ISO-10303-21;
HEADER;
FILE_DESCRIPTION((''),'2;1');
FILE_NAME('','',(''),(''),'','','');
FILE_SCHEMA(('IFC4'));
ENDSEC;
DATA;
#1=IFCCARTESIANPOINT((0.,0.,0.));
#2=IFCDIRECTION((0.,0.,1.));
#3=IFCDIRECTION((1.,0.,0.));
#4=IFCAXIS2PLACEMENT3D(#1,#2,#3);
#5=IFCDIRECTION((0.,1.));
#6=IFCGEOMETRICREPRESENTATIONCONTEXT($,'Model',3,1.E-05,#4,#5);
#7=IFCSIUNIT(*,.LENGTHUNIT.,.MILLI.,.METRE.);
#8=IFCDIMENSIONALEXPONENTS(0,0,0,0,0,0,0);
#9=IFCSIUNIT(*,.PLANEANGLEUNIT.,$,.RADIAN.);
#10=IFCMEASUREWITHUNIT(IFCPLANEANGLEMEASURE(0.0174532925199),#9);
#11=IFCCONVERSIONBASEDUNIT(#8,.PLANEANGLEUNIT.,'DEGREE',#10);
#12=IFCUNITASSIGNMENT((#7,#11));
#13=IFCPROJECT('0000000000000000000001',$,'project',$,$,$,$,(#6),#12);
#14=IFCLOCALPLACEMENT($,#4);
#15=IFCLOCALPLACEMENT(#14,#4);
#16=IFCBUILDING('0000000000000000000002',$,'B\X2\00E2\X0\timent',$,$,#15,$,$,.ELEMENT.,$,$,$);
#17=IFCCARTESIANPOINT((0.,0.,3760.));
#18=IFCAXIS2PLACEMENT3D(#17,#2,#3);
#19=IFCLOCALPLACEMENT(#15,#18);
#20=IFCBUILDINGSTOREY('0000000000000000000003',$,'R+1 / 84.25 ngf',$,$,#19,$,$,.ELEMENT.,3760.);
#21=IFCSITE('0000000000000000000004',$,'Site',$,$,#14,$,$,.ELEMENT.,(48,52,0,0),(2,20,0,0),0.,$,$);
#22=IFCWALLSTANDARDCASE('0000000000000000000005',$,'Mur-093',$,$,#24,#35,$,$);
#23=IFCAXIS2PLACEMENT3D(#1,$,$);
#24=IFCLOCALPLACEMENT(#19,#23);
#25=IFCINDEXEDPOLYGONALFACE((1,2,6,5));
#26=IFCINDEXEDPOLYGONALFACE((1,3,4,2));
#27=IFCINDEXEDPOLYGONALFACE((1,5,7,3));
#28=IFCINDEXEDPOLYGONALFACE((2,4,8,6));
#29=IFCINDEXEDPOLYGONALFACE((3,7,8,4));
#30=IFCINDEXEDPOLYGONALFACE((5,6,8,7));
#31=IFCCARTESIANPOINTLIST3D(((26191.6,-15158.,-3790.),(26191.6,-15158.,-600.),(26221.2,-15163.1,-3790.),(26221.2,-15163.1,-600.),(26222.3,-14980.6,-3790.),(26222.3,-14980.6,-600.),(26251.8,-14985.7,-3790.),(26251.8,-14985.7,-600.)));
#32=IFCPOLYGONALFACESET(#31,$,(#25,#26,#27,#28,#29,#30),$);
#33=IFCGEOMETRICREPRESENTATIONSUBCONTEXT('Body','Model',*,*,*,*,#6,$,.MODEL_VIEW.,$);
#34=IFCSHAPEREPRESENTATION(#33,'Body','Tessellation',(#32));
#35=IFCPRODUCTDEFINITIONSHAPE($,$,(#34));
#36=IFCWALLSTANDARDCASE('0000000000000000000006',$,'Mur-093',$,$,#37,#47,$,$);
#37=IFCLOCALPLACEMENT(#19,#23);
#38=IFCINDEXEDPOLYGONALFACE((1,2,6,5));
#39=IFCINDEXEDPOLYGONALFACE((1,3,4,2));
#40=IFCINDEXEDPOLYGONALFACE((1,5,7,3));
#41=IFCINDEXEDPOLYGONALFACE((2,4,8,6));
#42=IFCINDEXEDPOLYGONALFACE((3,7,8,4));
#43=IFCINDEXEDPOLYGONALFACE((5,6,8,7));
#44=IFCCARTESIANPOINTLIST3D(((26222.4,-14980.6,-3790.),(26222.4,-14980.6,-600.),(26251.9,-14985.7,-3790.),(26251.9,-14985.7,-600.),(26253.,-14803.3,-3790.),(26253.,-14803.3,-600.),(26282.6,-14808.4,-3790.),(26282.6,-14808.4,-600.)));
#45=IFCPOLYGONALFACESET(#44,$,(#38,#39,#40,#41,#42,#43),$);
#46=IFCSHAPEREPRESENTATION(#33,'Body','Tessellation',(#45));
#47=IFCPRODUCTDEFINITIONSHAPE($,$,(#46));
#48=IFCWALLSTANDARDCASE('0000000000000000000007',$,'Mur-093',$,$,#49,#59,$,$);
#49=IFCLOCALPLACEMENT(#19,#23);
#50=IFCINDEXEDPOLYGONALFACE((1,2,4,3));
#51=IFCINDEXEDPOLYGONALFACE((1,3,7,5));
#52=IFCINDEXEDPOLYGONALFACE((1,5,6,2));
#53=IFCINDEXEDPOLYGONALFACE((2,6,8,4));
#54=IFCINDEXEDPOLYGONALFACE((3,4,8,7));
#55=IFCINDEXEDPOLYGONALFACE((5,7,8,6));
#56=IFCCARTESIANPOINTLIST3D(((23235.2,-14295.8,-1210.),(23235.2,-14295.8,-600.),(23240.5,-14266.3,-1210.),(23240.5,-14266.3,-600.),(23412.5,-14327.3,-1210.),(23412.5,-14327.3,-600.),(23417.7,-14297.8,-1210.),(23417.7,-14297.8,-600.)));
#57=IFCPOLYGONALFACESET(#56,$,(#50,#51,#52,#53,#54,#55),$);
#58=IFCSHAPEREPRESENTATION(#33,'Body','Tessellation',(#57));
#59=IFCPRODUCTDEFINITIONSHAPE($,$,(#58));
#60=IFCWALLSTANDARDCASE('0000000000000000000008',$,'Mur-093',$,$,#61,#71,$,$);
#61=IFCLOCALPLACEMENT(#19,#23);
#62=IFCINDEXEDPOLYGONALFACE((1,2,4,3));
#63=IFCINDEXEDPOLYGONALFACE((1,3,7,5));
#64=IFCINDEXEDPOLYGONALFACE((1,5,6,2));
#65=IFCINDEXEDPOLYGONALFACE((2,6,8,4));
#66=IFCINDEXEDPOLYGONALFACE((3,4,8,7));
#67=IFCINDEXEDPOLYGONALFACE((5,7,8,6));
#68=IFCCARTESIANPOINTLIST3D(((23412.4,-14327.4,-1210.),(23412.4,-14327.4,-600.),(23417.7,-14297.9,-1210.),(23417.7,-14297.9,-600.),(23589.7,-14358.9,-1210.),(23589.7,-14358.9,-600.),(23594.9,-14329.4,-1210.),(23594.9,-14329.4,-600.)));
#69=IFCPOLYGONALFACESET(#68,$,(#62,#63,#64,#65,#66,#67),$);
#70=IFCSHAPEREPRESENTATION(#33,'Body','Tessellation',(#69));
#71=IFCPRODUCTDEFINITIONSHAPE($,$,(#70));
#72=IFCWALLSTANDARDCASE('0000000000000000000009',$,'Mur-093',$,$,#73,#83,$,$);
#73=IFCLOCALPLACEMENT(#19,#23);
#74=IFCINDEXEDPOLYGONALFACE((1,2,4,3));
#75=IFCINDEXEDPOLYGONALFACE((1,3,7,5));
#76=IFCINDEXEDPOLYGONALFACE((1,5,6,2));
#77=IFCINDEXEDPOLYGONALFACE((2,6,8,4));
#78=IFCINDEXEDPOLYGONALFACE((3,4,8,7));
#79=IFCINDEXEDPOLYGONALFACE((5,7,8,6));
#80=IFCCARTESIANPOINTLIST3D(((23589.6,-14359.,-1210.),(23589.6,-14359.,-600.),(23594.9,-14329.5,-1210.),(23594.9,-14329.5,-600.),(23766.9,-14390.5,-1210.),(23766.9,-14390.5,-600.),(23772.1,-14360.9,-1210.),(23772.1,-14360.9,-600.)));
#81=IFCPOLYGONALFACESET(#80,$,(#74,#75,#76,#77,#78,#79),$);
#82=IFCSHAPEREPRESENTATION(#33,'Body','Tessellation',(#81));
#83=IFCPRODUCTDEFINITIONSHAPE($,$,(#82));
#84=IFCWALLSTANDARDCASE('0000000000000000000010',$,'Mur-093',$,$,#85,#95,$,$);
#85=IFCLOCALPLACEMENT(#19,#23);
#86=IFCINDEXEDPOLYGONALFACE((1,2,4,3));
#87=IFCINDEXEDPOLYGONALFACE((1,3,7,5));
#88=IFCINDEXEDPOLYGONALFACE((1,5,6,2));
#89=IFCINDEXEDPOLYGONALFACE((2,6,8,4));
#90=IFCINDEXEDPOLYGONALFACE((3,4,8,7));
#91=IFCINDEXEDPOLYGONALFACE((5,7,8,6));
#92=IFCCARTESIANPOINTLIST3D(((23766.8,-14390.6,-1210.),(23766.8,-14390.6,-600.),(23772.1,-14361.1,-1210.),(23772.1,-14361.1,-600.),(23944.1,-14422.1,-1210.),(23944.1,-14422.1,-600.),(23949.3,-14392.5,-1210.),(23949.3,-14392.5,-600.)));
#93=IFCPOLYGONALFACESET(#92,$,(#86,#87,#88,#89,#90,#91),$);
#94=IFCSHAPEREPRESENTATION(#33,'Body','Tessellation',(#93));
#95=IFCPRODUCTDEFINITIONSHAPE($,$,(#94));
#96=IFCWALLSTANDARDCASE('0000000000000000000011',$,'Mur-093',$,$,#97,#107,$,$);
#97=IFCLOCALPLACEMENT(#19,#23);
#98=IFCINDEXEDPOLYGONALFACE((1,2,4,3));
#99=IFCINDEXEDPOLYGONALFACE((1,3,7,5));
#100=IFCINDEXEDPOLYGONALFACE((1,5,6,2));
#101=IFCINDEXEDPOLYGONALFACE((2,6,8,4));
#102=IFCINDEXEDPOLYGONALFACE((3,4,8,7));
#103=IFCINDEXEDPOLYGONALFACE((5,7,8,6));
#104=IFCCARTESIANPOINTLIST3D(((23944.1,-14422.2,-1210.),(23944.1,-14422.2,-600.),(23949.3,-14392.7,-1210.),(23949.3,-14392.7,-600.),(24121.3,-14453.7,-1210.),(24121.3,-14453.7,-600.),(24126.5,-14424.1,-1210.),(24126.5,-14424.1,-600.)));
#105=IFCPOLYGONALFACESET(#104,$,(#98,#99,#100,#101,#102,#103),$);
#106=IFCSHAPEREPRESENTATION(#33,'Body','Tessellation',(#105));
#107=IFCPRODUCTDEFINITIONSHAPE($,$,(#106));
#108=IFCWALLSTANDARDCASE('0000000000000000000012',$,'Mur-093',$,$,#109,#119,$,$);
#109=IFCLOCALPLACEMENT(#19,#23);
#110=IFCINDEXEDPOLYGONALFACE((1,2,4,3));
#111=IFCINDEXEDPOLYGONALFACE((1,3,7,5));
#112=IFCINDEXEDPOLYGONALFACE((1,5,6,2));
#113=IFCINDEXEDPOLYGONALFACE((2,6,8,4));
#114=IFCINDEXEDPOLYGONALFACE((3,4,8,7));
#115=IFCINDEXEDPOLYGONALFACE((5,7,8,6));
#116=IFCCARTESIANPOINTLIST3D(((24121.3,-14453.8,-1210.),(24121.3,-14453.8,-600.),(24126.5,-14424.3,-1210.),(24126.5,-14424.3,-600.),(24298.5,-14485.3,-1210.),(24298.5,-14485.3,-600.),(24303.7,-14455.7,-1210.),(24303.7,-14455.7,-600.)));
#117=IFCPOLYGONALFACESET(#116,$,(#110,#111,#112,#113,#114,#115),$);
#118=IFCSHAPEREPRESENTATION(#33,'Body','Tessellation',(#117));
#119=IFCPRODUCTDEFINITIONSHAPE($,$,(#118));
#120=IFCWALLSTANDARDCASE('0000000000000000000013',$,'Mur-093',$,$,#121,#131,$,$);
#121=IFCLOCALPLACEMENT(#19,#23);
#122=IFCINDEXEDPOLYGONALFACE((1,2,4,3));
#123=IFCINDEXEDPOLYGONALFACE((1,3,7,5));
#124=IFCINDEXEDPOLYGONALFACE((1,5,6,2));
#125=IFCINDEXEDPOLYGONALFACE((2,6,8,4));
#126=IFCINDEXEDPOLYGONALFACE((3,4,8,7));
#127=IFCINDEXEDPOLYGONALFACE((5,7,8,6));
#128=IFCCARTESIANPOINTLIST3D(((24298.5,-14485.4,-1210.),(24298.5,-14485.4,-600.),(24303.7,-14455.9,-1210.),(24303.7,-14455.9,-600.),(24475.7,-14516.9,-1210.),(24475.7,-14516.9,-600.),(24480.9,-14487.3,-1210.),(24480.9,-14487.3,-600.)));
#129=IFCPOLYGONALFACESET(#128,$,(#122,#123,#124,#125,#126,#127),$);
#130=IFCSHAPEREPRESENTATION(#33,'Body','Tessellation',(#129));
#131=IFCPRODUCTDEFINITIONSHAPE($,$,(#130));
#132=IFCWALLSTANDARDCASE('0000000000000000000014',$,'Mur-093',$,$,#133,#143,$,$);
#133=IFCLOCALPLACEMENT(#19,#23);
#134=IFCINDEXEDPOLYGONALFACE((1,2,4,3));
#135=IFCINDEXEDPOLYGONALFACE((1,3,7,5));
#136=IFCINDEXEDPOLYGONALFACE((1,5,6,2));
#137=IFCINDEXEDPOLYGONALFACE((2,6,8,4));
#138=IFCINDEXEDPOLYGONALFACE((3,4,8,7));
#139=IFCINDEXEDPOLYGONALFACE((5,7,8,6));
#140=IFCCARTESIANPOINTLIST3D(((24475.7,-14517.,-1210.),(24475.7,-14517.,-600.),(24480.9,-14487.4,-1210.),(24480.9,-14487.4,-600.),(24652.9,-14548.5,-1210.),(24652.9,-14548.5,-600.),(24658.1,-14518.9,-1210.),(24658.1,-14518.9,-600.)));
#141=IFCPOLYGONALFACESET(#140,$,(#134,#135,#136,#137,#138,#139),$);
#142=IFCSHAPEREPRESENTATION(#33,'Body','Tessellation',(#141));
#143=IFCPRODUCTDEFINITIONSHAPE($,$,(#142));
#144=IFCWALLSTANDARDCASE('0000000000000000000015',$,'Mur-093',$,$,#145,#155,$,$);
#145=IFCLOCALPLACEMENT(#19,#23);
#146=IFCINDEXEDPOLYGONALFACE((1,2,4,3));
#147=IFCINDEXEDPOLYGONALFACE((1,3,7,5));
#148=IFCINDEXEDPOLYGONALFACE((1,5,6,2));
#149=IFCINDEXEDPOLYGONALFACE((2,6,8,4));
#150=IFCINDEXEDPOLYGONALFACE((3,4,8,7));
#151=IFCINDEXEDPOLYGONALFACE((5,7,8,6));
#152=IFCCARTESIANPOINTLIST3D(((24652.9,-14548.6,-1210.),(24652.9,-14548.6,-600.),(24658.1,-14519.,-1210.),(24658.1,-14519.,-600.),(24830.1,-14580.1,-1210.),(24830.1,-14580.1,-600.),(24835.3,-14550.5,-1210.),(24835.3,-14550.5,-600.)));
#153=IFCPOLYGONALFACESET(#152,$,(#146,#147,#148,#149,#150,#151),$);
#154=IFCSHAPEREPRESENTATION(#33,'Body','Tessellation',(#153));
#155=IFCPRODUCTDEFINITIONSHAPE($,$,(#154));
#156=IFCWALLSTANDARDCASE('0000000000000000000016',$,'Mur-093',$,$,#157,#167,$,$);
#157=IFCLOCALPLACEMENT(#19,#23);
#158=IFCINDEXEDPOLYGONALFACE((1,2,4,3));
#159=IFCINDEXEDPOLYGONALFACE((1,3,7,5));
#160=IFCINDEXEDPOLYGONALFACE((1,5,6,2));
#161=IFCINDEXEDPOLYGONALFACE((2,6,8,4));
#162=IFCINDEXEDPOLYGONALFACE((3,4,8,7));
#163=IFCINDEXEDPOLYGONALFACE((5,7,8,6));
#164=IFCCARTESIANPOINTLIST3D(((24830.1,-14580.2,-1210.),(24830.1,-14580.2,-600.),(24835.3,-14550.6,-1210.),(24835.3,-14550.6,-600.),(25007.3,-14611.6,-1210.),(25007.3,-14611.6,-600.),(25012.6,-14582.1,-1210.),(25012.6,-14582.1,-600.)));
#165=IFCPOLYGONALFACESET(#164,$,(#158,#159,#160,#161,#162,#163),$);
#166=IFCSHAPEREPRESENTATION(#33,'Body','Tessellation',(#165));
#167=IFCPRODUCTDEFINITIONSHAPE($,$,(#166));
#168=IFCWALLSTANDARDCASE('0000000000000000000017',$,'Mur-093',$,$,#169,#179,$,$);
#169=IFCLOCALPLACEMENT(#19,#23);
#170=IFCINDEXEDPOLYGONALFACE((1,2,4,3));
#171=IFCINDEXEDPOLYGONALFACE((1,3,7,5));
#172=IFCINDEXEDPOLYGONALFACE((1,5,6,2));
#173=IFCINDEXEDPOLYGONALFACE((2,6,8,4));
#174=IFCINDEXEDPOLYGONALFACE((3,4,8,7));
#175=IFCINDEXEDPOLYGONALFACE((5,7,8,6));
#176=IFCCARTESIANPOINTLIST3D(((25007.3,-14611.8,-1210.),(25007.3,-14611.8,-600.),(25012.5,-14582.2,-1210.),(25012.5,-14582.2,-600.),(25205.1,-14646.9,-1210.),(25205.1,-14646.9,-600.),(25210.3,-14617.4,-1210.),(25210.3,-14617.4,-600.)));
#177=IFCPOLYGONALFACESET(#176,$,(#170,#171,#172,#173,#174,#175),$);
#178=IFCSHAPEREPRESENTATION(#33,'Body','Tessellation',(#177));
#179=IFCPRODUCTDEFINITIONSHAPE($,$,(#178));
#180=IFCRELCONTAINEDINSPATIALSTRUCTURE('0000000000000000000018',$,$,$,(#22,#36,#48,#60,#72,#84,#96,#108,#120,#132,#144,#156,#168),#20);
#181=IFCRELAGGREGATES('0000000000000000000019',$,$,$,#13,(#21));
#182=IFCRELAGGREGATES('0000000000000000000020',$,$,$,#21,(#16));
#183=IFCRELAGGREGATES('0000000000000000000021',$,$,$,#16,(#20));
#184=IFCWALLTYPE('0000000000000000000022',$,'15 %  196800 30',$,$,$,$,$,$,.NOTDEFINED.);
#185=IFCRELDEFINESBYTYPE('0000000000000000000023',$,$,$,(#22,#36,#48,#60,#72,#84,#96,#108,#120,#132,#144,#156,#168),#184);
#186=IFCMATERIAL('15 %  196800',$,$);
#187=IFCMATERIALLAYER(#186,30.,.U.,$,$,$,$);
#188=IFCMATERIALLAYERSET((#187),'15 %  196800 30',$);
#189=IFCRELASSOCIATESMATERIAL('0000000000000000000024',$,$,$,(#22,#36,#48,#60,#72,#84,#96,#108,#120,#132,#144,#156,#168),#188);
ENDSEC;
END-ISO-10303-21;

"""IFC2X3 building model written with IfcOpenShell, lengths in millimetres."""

from ifc_helpers import new_model, entity, si_unit, converted_unit, direction, frame, origin_with_axes, place, context, subcontext, project, spatial, polyline, outline, extrude, material, layer, layer_set, layer_usage, type_object, element, save


model = new_model("IFC2X3")

# Units and contexts
model_context = context("Model", 3, precision=1e-05, world=origin_with_axes(), true_north=direction((0.0, 1.0)))
body_context = subcontext(model_context, "Body", "Model", "MODEL_VIEW")
ifc_project = project(units=[si_unit("LENGTHUNIT", "METRE", prefix="MILLI"), converted_unit("PLANEANGLEUNIT", "DEGREE", entity("IfcPlaneAngleMeasure", 0.0174532925199), si_unit("PLANEANGLEUNIT", "RADIAN"), dimensions=[0, 0, 0, 0, 0, 0, 0])], contexts=[model_context])

# Site, building, storey
site_placement = place(None, origin_with_axes())
site = spatial("IfcSite", under=ifc_project, at=site_placement, Name="Site", CompositionType="ELEMENT", RefLatitude=(48, 52, 0, 0), RefLongitude=(2, 20, 0, 0), RefElevation=0.0)
building_placement = place(site_placement, origin_with_axes())
building = spatial("IfcBuilding", under=site, at=building_placement, Name="Bâtiment", CompositionType="ELEMENT")
storey_placement = place(building_placement, frame((0.0, 0.0, 3760.0), z_axis=(0.0, 0.0, 1.0), x_axis=(1.0, 0.0, 0.0)))
storey = spatial("IfcBuildingStorey", under=building, at=storey_placement, Name="R+1 / 84.25 ngf", CompositionType="ELEMENT", Elevation=3760.0)

# Walls
ifc_material = material(Name="15 %  196800")
ifc_layer = layer(ifc_material, 30.0, ventilated="UNKNOWN")
ifc_layer_set = layer_set([ifc_layer], Name="15 %  196800 30")
ifc_layer_usage_1 = layer_usage(ifc_layer_set, "AXIS2", "NEGATIVE", 30.0)
wall_type = type_object("IfcWallType", Name="15 %  196800 30", PredefinedType="NOTDEFINED")
wall_1_placement = place(storey_placement, frame((26222.3, -14980.6, -3790.0), z_axis=(0.0, 0.0, 1.0), x_axis=(-0.170069, -0.985432, 0.0)))
element("IfcWallStandardCase", 1, at=wall_1_placement, inside=storey, type_object=wall_type, material=ifc_layer_usage_1, Name="Mur-093", context=body_context, shape_type="SweptSolid", body=[
    extrude(outline(polyline([(0.0, 0.0), (180.0, 0.0), (180.0, 30.0), (0.0, 30.0), (0.0, 0.0)])), origin_with_axes(), (0.0, 0.0, 1.0), 3190.0),
])
ifc_layer_usage_2 = layer_usage(ifc_layer_set, "AXIS2", "NEGATIVE", 30.0)
wall_2_placement = place(storey_placement, frame((26253.0, -14803.3, -3790.0), z_axis=(0.0, 0.0, 1.0), x_axis=(-0.170069, -0.985432, 0.0)))
element("IfcWallStandardCase", 2, at=wall_2_placement, inside=storey, type_object=wall_type, material=ifc_layer_usage_2, Name="Mur-093", context=body_context, shape_type="SweptSolid", body=[
    extrude(outline(polyline([(0.0, 0.0), (180.0, 0.0), (180.0, 30.0), (0.0, 30.0), (0.0, 0.0)])), origin_with_axes(), (0.0, 0.0, 1.0), 3190.0),
])
ifc_layer_usage_3 = layer_usage(ifc_layer_set, "AXIS2", "NEGATIVE", 30.0)
wall_3_placement = place(storey_placement, frame((23417.7, -14297.8, -1210.0), z_axis=(0.0, 0.0, 1.0), x_axis=(-0.984592, 0.174869, 0.0)))
element("IfcWallStandardCase", 3, at=wall_3_placement, inside=storey, type_object=wall_type, material=ifc_layer_usage_3, Name="Mur-093", context=body_context, shape_type="SweptSolid", body=[
    extrude(outline(polyline([(0.0, 0.0), (180.0, 0.0), (180.0, 30.0), (0.0, 30.0), (0.0, 0.0)])), origin_with_axes(), (0.0, 0.0, 1.0), 610.0),
])
ifc_layer_usage_4 = layer_usage(ifc_layer_set, "AXIS2", "NEGATIVE", 30.0)
wall_4_placement = place(storey_placement, frame((23594.9, -14329.4, -1210.0), z_axis=(0.0, 0.0, 1.0), x_axis=(-0.984592, 0.174869, 0.0)))
element("IfcWallStandardCase", 4, at=wall_4_placement, inside=storey, type_object=wall_type, material=ifc_layer_usage_4, Name="Mur-093", context=body_context, shape_type="SweptSolid", body=[
    extrude(outline(polyline([(0.0, 0.0), (180.0, 0.0), (180.0, 30.0), (0.0, 30.0), (0.0, 0.0)])), origin_with_axes(), (0.0, 0.0, 1.0), 610.0),
])
ifc_layer_usage_5 = layer_usage(ifc_layer_set, "AXIS2", "NEGATIVE", 30.0)
wall_5_placement = place(storey_placement, frame((23772.1, -14360.9, -1210.0), z_axis=(0.0, 0.0, 1.0), x_axis=(-0.984592, 0.174869, 0.0)))
element("IfcWallStandardCase", 5, at=wall_5_placement, inside=storey, type_object=wall_type, material=ifc_layer_usage_5, Name="Mur-093", context=body_context, shape_type="SweptSolid", body=[
    extrude(outline(polyline([(0.0, 0.0), (180.0, 0.0), (180.0, 30.0), (0.0, 30.0), (0.0, 0.0)])), origin_with_axes(), (0.0, 0.0, 1.0), 610.0),
])
ifc_layer_usage_6 = layer_usage(ifc_layer_set, "AXIS2", "NEGATIVE", 30.0)
wall_6_placement = place(storey_placement, frame((23949.3, -14392.5, -1210.0), z_axis=(0.0, 0.0, 1.0), x_axis=(-0.984592, 0.174869, 0.0)))
element("IfcWallStandardCase", 6, at=wall_6_placement, inside=storey, type_object=wall_type, material=ifc_layer_usage_6, Name="Mur-093", context=body_context, shape_type="SweptSolid", body=[
    extrude(outline(polyline([(0.0, 0.0), (180.0, 0.0), (180.0, 30.0), (0.0, 30.0), (0.0, 0.0)])), origin_with_axes(), (0.0, 0.0, 1.0), 610.0),
])
ifc_layer_usage_7 = layer_usage(ifc_layer_set, "AXIS2", "NEGATIVE", 30.0)
wall_7_placement = place(storey_placement, frame((24126.5, -14424.1, -1210.0), z_axis=(0.0, 0.0, 1.0), x_axis=(-0.984592, 0.174869, 0.0)))
element("IfcWallStandardCase", 7, at=wall_7_placement, inside=storey, type_object=wall_type, material=ifc_layer_usage_7, Name="Mur-093", context=body_context, shape_type="SweptSolid", body=[
    extrude(outline(polyline([(0.0, 0.0), (180.0, 0.0), (180.0, 30.0), (0.0, 30.0), (0.0, 0.0)])), origin_with_axes(), (0.0, 0.0, 1.0), 610.0),
])
ifc_layer_usage_8 = layer_usage(ifc_layer_set, "AXIS2", "NEGATIVE", 30.0)
wall_8_placement = place(storey_placement, frame((24303.7, -14455.7, -1210.0), z_axis=(0.0, 0.0, 1.0), x_axis=(-0.984592, 0.174869, 0.0)))
element("IfcWallStandardCase", 8, at=wall_8_placement, inside=storey, type_object=wall_type, material=ifc_layer_usage_8, Name="Mur-093", context=body_context, shape_type="SweptSolid", body=[
    extrude(outline(polyline([(0.0, 0.0), (180.0, 0.0), (180.0, 30.0), (0.0, 30.0), (0.0, 0.0)])), origin_with_axes(), (0.0, 0.0, 1.0), 610.0),
])
ifc_layer_usage_9 = layer_usage(ifc_layer_set, "AXIS2", "NEGATIVE", 30.0)
wall_9_placement = place(storey_placement, frame((24480.9, -14487.3, -1210.0), z_axis=(0.0, 0.0, 1.0), x_axis=(-0.984592, 0.174869, 0.0)))
element("IfcWallStandardCase", 9, at=wall_9_placement, inside=storey, type_object=wall_type, material=ifc_layer_usage_9, Name="Mur-093", context=body_context, shape_type="SweptSolid", body=[
    extrude(outline(polyline([(0.0, 0.0), (180.0, 0.0), (180.0, 30.0), (0.0, 30.0), (0.0, 0.0)])), origin_with_axes(), (0.0, 0.0, 1.0), 610.0),
])
ifc_layer_usage_10 = layer_usage(ifc_layer_set, "AXIS2", "NEGATIVE", 30.0)
wall_10_placement = place(storey_placement, frame((24658.1, -14518.9, -1210.0), z_axis=(0.0, 0.0, 1.0), x_axis=(-0.984592, 0.174869, 0.0)))
element("IfcWallStandardCase", 10, at=wall_10_placement, inside=storey, type_object=wall_type, material=ifc_layer_usage_10, Name="Mur-093", context=body_context, shape_type="SweptSolid", body=[
    extrude(outline(polyline([(0.0, 0.0), (180.0, 0.0), (180.0, 30.0), (0.0, 30.0), (0.0, 0.0)])), origin_with_axes(), (0.0, 0.0, 1.0), 610.0),
])
ifc_layer_usage_11 = layer_usage(ifc_layer_set, "AXIS2", "NEGATIVE", 30.0)
wall_11_placement = place(storey_placement, frame((24835.3, -14550.5, -1210.0), z_axis=(0.0, 0.0, 1.0), x_axis=(-0.984592, 0.174869, 0.0)))
element("IfcWallStandardCase", 11, at=wall_11_placement, inside=storey, type_object=wall_type, material=ifc_layer_usage_11, Name="Mur-093", context=body_context, shape_type="SweptSolid", body=[
    extrude(outline(polyline([(0.0, 0.0), (180.0, 0.0), (180.0, 30.0), (0.0, 30.0), (0.0, 0.0)])), origin_with_axes(), (0.0, 0.0, 1.0), 610.0),
])
ifc_layer_usage_12 = layer_usage(ifc_layer_set, "AXIS2", "NEGATIVE", 30.0)
wall_12_placement = place(storey_placement, frame((25012.6, -14582.1, -1210.0), z_axis=(0.0, 0.0, 1.0), x_axis=(-0.984592, 0.174869, 0.0)))
element("IfcWallStandardCase", 12, at=wall_12_placement, inside=storey, type_object=wall_type, material=ifc_layer_usage_12, Name="Mur-093", context=body_context, shape_type="SweptSolid", body=[
    extrude(outline(polyline([(0.0, 0.0), (180.0, 0.0), (180.0, 30.0), (0.0, 30.0), (0.0, 0.0)])), origin_with_axes(), (0.0, 0.0, 1.0), 610.0),
])
ifc_layer_usage_13 = layer_usage(ifc_layer_set, "AXIS2", "NEGATIVE", 30.0)
wall_13_placement = place(storey_placement, frame((25210.3, -14617.4, -1210.0), z_axis=(0.0, 0.0, 1.0), x_axis=(-0.984546, 0.175127, 0.0)))
element("IfcWallStandardCase", 13, at=wall_13_placement, inside=storey, type_object=wall_type, material=ifc_layer_usage_13, Name="Mur-093", context=body_context, shape_type="SweptSolid", body=[
    extrude(outline(polyline([(0.0, 0.0), (200.9, 0.0), (200.9, 30.0), (0.0, 30.0), (0.0, 0.0)])), origin_with_axes(), (0.0, 0.0, 1.0), 610.0),
])

save(model, "model.ifc")
